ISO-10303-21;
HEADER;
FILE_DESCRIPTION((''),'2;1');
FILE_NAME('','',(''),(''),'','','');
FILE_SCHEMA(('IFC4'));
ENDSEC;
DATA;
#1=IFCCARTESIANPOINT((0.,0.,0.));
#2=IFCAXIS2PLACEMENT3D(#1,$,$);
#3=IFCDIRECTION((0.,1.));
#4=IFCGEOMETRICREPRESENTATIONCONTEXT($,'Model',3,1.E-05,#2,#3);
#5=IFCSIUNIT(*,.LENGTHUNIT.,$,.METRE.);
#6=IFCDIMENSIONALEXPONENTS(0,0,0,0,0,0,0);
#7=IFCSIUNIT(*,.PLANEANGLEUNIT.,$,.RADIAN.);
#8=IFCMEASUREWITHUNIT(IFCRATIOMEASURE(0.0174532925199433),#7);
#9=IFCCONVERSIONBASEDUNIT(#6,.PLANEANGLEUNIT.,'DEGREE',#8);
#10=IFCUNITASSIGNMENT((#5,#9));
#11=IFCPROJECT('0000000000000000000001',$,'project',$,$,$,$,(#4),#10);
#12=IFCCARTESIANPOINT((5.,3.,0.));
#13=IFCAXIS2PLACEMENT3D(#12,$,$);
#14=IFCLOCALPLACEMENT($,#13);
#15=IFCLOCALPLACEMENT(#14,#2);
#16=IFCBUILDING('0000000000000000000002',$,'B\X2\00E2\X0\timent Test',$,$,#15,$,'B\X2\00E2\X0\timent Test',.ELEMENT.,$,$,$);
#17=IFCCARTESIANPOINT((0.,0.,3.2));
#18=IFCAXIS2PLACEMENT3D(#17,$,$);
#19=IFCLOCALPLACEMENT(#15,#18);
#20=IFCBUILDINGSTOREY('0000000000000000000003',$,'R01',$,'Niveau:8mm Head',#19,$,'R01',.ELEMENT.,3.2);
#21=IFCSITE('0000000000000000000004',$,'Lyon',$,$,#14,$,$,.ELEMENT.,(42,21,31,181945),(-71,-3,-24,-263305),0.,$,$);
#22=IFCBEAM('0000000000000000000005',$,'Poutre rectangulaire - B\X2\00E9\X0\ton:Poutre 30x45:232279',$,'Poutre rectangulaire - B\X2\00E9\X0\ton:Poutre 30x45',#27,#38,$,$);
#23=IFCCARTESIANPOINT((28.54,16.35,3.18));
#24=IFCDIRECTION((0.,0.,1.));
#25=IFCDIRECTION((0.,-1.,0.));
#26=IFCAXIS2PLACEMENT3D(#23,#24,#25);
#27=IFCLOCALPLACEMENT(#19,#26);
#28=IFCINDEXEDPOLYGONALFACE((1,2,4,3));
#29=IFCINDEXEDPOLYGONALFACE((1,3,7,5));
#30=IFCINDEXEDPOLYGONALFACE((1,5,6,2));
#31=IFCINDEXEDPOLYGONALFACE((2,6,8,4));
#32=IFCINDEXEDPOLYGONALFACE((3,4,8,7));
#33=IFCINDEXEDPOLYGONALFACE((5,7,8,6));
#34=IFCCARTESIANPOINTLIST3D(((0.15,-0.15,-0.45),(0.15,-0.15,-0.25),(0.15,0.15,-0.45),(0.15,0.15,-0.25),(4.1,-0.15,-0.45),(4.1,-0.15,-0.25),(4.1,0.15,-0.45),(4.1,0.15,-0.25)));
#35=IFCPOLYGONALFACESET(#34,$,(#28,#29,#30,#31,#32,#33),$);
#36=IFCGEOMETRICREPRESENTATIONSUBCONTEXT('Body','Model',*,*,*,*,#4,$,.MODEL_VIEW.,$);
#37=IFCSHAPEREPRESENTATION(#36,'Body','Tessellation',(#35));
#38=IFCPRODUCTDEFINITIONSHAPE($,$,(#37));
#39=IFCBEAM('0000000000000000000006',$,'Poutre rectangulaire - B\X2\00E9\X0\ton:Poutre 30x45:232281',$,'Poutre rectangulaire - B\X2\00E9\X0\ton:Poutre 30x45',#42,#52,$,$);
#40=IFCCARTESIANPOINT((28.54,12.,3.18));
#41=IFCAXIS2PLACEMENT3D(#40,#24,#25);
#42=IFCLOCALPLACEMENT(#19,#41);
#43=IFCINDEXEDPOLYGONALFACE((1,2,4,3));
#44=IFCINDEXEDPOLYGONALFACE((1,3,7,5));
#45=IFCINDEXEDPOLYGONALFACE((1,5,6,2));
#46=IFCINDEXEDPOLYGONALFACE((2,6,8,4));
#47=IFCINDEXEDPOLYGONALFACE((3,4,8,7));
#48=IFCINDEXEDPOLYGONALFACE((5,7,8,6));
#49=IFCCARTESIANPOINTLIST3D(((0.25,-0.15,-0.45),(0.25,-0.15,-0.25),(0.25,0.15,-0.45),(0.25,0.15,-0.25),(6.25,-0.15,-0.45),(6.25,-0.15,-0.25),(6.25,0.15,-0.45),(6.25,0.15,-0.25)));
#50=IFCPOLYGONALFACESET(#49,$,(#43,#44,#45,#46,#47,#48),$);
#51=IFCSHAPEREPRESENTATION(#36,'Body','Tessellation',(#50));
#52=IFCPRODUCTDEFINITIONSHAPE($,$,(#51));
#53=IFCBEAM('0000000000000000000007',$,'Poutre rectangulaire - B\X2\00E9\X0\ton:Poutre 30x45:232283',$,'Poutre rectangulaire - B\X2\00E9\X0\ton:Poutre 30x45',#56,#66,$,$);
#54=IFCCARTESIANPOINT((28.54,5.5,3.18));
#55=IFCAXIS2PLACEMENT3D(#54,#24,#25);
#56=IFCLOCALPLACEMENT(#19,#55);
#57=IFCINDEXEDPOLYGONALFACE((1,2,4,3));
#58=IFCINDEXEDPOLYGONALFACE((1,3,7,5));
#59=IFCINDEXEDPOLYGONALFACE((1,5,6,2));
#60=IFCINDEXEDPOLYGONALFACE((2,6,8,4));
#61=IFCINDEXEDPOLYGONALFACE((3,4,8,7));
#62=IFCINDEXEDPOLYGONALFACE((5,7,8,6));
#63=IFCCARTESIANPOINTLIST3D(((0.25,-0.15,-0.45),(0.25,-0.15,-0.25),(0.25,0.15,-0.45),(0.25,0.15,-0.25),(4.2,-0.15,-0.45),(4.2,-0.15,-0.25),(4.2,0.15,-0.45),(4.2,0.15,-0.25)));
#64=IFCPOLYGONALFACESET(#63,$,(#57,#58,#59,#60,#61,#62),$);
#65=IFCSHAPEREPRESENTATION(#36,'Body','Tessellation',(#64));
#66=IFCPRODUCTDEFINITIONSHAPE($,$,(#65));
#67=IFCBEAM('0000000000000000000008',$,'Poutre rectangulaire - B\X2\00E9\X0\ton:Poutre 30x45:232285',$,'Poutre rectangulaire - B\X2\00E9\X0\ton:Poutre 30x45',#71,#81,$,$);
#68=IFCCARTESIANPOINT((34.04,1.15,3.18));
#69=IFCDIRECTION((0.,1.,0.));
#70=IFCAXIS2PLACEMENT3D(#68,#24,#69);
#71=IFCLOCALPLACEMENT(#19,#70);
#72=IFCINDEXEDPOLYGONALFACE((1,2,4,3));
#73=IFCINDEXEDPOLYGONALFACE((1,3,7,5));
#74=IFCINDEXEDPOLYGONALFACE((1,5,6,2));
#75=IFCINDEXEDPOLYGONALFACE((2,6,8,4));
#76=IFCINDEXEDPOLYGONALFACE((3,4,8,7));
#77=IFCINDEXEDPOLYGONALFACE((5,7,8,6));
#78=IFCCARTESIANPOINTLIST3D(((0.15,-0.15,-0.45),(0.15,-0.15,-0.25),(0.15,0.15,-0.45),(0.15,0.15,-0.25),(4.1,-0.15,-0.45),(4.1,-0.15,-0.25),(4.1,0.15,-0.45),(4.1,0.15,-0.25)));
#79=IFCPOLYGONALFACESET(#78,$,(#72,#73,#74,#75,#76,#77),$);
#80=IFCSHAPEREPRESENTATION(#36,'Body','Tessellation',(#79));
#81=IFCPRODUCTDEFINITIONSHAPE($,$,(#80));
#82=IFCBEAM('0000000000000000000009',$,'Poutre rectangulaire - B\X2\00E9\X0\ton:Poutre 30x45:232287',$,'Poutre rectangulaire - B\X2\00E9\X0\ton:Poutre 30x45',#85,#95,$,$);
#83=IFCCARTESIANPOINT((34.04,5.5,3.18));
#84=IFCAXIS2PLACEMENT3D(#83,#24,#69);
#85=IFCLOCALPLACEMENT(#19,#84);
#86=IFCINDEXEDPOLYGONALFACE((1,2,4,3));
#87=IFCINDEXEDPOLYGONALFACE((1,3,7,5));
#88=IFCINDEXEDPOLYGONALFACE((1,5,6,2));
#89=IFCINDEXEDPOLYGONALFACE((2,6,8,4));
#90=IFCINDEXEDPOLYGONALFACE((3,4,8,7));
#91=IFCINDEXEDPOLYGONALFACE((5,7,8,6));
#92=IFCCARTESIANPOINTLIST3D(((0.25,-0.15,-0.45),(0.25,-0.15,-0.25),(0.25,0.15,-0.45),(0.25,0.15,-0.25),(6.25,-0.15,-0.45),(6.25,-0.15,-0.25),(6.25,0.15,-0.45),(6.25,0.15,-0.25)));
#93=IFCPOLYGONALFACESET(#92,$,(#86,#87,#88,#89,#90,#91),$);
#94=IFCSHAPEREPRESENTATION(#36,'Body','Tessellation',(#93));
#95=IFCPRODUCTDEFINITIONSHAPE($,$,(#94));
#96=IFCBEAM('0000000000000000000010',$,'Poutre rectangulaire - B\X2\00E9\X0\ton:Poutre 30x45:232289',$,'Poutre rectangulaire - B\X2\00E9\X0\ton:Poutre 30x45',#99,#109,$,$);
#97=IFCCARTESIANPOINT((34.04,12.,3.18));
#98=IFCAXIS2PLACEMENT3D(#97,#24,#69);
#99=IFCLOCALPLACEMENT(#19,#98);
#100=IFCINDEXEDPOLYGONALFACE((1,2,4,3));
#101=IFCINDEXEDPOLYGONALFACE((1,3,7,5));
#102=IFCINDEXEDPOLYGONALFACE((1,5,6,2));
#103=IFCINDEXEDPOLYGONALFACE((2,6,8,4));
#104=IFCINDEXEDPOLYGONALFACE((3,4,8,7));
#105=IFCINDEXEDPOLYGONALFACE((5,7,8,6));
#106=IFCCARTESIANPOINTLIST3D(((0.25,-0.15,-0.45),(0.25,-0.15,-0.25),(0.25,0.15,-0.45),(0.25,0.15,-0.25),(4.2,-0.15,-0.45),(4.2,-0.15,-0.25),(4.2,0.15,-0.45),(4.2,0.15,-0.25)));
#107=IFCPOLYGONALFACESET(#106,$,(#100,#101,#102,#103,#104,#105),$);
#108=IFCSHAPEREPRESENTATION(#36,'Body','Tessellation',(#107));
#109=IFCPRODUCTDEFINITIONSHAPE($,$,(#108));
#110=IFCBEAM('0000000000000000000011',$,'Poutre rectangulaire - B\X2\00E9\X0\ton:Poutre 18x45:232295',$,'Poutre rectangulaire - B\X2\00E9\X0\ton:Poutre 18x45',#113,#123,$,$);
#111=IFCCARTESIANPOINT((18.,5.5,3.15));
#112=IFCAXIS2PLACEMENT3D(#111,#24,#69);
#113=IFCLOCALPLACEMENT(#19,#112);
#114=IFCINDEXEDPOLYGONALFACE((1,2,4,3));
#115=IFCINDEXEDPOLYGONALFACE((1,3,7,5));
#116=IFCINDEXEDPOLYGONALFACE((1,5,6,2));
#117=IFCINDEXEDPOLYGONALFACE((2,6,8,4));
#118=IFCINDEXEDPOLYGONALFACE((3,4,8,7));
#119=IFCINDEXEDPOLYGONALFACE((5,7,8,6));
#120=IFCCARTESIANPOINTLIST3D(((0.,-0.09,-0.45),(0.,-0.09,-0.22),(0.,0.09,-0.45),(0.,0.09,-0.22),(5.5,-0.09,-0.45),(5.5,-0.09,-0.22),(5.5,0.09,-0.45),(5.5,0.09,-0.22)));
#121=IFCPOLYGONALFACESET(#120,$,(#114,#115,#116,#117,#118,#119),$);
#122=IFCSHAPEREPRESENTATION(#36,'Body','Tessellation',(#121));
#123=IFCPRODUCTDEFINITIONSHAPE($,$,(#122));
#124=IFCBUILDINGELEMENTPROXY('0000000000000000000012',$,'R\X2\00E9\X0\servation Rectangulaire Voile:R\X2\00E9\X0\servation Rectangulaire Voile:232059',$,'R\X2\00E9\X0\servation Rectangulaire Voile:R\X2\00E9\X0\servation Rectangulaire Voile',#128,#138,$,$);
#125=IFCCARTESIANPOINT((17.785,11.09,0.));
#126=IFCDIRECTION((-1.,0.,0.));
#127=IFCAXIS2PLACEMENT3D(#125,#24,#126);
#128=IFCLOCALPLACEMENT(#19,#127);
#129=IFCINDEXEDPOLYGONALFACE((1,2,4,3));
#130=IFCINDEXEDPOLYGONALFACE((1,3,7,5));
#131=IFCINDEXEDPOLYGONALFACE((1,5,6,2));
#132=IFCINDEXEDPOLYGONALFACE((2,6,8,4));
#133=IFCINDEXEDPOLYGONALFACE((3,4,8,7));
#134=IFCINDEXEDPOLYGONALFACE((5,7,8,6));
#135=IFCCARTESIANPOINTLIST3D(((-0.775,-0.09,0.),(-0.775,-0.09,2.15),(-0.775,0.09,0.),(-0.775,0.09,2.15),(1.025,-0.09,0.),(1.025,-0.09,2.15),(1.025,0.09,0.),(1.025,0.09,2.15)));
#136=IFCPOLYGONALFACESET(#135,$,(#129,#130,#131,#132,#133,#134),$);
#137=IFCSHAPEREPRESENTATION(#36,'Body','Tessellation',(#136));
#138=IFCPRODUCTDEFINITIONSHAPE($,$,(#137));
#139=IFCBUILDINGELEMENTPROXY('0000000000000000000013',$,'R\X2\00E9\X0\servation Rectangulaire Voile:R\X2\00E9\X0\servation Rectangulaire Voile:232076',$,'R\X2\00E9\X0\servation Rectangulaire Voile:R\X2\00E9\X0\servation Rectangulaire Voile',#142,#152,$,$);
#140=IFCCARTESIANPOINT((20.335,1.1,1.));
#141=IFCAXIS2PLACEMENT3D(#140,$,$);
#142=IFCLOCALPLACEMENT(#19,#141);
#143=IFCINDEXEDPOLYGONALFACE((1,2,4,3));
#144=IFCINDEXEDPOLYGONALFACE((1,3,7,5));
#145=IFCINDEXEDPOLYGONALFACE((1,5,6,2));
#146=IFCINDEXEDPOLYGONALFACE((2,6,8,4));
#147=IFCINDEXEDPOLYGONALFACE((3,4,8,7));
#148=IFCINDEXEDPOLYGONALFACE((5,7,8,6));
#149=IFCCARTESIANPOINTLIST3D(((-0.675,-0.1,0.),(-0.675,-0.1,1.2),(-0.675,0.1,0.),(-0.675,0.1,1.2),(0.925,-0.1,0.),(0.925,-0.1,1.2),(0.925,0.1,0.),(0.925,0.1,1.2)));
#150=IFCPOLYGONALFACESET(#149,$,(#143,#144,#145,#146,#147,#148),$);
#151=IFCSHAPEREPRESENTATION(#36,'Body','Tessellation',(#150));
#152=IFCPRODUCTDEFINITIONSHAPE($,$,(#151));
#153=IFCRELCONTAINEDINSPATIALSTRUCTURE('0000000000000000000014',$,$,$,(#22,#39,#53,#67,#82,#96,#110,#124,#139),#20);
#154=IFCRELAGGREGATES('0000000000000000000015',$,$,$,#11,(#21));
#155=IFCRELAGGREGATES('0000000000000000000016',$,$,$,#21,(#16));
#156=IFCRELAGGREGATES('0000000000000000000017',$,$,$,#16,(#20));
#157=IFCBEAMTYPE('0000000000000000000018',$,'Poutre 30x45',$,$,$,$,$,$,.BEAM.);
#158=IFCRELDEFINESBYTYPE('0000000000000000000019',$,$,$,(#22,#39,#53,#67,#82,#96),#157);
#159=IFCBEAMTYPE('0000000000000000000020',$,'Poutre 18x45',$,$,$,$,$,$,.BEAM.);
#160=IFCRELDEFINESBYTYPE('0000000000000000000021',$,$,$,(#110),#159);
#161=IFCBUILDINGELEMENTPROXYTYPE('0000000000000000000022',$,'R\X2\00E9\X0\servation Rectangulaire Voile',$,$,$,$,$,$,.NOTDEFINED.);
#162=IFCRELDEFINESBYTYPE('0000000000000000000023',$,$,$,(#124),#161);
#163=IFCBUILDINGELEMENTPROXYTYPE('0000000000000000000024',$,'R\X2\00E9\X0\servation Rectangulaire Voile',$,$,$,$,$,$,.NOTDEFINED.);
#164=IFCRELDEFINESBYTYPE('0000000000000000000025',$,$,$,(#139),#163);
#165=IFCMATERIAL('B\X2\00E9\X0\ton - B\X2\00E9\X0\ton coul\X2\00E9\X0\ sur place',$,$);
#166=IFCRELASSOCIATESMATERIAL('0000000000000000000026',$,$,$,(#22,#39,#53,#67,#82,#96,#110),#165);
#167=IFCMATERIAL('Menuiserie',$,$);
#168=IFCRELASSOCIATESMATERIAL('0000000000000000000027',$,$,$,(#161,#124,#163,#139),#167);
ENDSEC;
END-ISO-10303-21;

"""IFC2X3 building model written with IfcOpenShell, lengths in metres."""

from ifc_helpers import new_model, entity, si_unit, converted_unit, direction, frame, frame_2d, origin, origin_2d_with_axis, place, context, subcontext, project, spatial, rectangle, extrude, source, transform, mapped, material, type_object, type_shapes, element, save


model = new_model("IFC2X3")

# Units and contexts
model_context = context("Model", 3, precision=1e-05, world=origin(), true_north=direction((0.0, 1.0)))
body_context = subcontext(model_context, "Body", "Model", "MODEL_VIEW")
ifc_project = project(units=[si_unit("LENGTHUNIT", "METRE"), converted_unit("PLANEANGLEUNIT", "DEGREE", entity("IfcRatioMeasure", 0.0174532925199433), si_unit("PLANEANGLEUNIT", "RADIAN"), dimensions=[0, 0, 0, 0, 0, 0, 0])], contexts=[model_context])

# Site, building, storey
site_placement = place(None, frame((5.0, 3.0, 0.0)))
site = spatial("IfcSite", under=ifc_project, at=site_placement, Name="Lyon", CompositionType="ELEMENT", RefLatitude=(42, 21, 31, 181945), RefLongitude=(-71, -3, -24, -263305), RefElevation=0.0)
building_placement = place(site_placement, origin())
building = spatial("IfcBuilding", under=site, at=building_placement, Name="Bâtiment Test", LongName="Bâtiment Test", CompositionType="ELEMENT")
storey_placement = place(building_placement, frame((0.0, 0.0, 3.2)))
storey = spatial("IfcBuildingStorey", under=building, at=storey_placement, Name="R01", ObjectType="Niveau:8mm Head", LongName="R01", CompositionType="ELEMENT", Elevation=3.2)

# Beams
ifc_material_1 = material(Name="Béton - Béton coulé sur place")
beam_type_1 = type_object("IfcBeamType", Name="Poutre 30x45", PredefinedType="BEAM")
beam_1_placement = place(storey_placement, frame((28.54, 16.35, 3.18), z_axis=(0.0, 0.0, 1.0), x_axis=(0.0, -1.0, 0.0)))
element("IfcBeam", 1, at=beam_1_placement, inside=storey, type_object=beam_type_1, material=ifc_material_1, Name="Poutre rectangulaire - Béton:Poutre 30x45:232279", ObjectType="Poutre rectangulaire - Béton:Poutre 30x45", context=body_context, shape_type="SweptSolid", body=[
    extrude(rectangle(XDim=0.2, YDim=0.3, at=origin_2d_with_axis()), frame((0.15, 0.0, -0.35), z_axis=(1.0, 0.0, 0.0), x_axis=(0.0, 0.0, -1.0)), (0.0, 0.0, 1.0), 3.95),
])
beam_2_placement = place(storey_placement, frame((28.54, 12.0, 3.18), z_axis=(0.0, 0.0, 1.0), x_axis=(0.0, -1.0, 0.0)))
element("IfcBeam", 2, at=beam_2_placement, inside=storey, type_object=beam_type_1, material=ifc_material_1, Name="Poutre rectangulaire - Béton:Poutre 30x45:232281", ObjectType="Poutre rectangulaire - Béton:Poutre 30x45", context=body_context, shape_type="SweptSolid", body=[
    extrude(rectangle(XDim=0.2, YDim=0.3, at=frame_2d((0.0, 0.0), x_axis=(1.0, 0.0))), frame((0.25, 0.0, -0.35), z_axis=(1.0, 0.0, 0.0), x_axis=(0.0, 0.0, -1.0)), (0.0, 0.0, 1.0), 6.0),
])
beam_3_placement = place(storey_placement, frame((28.54, 5.5, 3.18), z_axis=(0.0, 0.0, 1.0), x_axis=(0.0, -1.0, 0.0)))
element("IfcBeam", 3, at=beam_3_placement, inside=storey, type_object=beam_type_1, material=ifc_material_1, Name="Poutre rectangulaire - Béton:Poutre 30x45:232283", ObjectType="Poutre rectangulaire - Béton:Poutre 30x45", context=body_context, shape_type="SweptSolid", body=[
    extrude(rectangle(XDim=0.2, YDim=0.3, at=origin_2d_with_axis()), frame((0.25, 0.0, -0.35), z_axis=(1.0, 0.0, 0.0), x_axis=(0.0, 0.0, -1.0)), (0.0, 0.0, 1.0), 3.95),
])
beam_4_placement = place(storey_placement, frame((34.04, 1.15, 3.18), z_axis=(0.0, 0.0, 1.0), x_axis=(0.0, 1.0, 0.0)))
element("IfcBeam", 4, at=beam_4_placement, inside=storey, type_object=beam_type_1, material=ifc_material_1, Name="Poutre rectangulaire - Béton:Poutre 30x45:232285", ObjectType="Poutre rectangulaire - Béton:Poutre 30x45", context=body_context, shape_type="SweptSolid", body=[
    extrude(rectangle(XDim=0.2, YDim=0.3, at=frame_2d((0.0, 0.0), x_axis=(1.0, 0.0))), frame((0.15, 0.0, -0.35), z_axis=(1.0, 0.0, 0.0), x_axis=(0.0, 0.0, -1.0)), (0.0, 0.0, 1.0), 3.95),
])
beam_5_placement = place(storey_placement, frame((34.04, 5.5, 3.18), z_axis=(0.0, 0.0, 1.0), x_axis=(0.0, 1.0, 0.0)))
element("IfcBeam", 5, at=beam_5_placement, inside=storey, type_object=beam_type_1, material=ifc_material_1, Name="Poutre rectangulaire - Béton:Poutre 30x45:232287", ObjectType="Poutre rectangulaire - Béton:Poutre 30x45", context=body_context, shape_type="SweptSolid", body=[
    extrude(rectangle(XDim=0.2, YDim=0.3, at=origin_2d_with_axis()), frame((0.25, 0.0, -0.35), z_axis=(1.0, 0.0, 0.0), x_axis=(0.0, 0.0, -1.0)), (0.0, 0.0, 1.0), 6.0),
])
beam_6_placement = place(storey_placement, frame((34.04, 12.0, 3.18), z_axis=(0.0, 0.0, 1.0), x_axis=(0.0, 1.0, 0.0)))
element("IfcBeam", 6, at=beam_6_placement, inside=storey, type_object=beam_type_1, material=ifc_material_1, Name="Poutre rectangulaire - Béton:Poutre 30x45:232289", ObjectType="Poutre rectangulaire - Béton:Poutre 30x45", context=body_context, shape_type="SweptSolid", body=[
    extrude(rectangle(XDim=0.2, YDim=0.3, at=frame_2d((0.0, 0.0), x_axis=(1.0, 0.0))), frame((0.25, 0.0, -0.35), z_axis=(1.0, 0.0, 0.0), x_axis=(0.0, 0.0, -1.0)), (0.0, 0.0, 1.0), 3.95),
])
beam_type_2 = type_object("IfcBeamType", Name="Poutre 18x45", PredefinedType="BEAM")
beam_7_placement = place(storey_placement, frame((18.0, 5.5, 3.15), z_axis=(0.0, 0.0, 1.0), x_axis=(0.0, 1.0, 0.0)))
element("IfcBeam", 7, at=beam_7_placement, inside=storey, type_object=beam_type_2, material=ifc_material_1, Name="Poutre rectangulaire - Béton:Poutre 18x45:232295", ObjectType="Poutre rectangulaire - Béton:Poutre 18x45", context=body_context, shape_type="SweptSolid", body=[
    extrude(rectangle(XDim=0.23, YDim=0.18, at=frame_2d((0.0, 0.0), x_axis=(1.0, 0.0))), frame((0.0, 0.0, -0.335), z_axis=(1.0, 0.0, 0.0), x_axis=(0.0, 0.0, -1.0)), (0.0, 0.0, 1.0), 5.5),
])

# Building element proxies
ifc_material_2 = material(Name="Menuiserie")
building_element_proxy_type_1 = type_object("IfcBuildingElementProxyType", Name="Réservation Rectangulaire Voile", PredefinedType="NOTDEFINED", material=ifc_material_2)
shared_shape_1 = source(origin(), body_context, "Body", "SweptSolid", [
    extrude(rectangle(XDim=0.18, YDim=1.8, at=origin_2d_with_axis()), frame((0.125, 0.0, 0.0), z_axis=(0.0, 0.0, 1.0), x_axis=(0.0, 1.0, 0.0)), (0.0, 0.0, 1.0), 2.15),
])
type_shapes(building_element_proxy_type_1, [shared_shape_1])
proxy_1_placement = place(storey_placement, frame((17.785, 11.09, 0.0), z_axis=(0.0, 0.0, 1.0), x_axis=(-1.0, 0.0, 0.0)))
element("IfcBuildingElementProxy", 8, at=proxy_1_placement, inside=storey, type_object=building_element_proxy_type_1, material=ifc_material_2, Name="Réservation Rectangulaire Voile:Réservation Rectangulaire Voile:232059", ObjectType="Réservation Rectangulaire Voile:Réservation Rectangulaire Voile", context=body_context, shape_type="MappedRepresentation", body=[
    mapped(shared_shape_1, transform((0.0, 0.0, 0.0), scale=1.0)),
])
building_element_proxy_type_2 = type_object("IfcBuildingElementProxyType", Name="Réservation Rectangulaire Voile", PredefinedType="NOTDEFINED", material=ifc_material_2)
shared_shape_2 = source(origin(), body_context, "Body", "SweptSolid", [
    extrude(rectangle(XDim=0.2, YDim=1.6, at=origin_2d_with_axis()), frame((0.125, 0.0, 0.0), z_axis=(0.0, 0.0, 1.0), x_axis=(0.0, 1.0, 0.0)), (0.0, 0.0, 1.0), 1.2),
])
type_shapes(building_element_proxy_type_2, [shared_shape_2])
proxy_2_placement = place(storey_placement, frame((20.335, 1.1, 1.0)))
element("IfcBuildingElementProxy", 9, at=proxy_2_placement, inside=storey, type_object=building_element_proxy_type_2, material=ifc_material_2, Name="Réservation Rectangulaire Voile:Réservation Rectangulaire Voile:232076", ObjectType="Réservation Rectangulaire Voile:Réservation Rectangulaire Voile", context=body_context, shape_type="MappedRepresentation", body=[
    mapped(shared_shape_2, transform((0.0, 0.0, 0.0), scale=1.0)),
])

save(model, "model.ifc")
